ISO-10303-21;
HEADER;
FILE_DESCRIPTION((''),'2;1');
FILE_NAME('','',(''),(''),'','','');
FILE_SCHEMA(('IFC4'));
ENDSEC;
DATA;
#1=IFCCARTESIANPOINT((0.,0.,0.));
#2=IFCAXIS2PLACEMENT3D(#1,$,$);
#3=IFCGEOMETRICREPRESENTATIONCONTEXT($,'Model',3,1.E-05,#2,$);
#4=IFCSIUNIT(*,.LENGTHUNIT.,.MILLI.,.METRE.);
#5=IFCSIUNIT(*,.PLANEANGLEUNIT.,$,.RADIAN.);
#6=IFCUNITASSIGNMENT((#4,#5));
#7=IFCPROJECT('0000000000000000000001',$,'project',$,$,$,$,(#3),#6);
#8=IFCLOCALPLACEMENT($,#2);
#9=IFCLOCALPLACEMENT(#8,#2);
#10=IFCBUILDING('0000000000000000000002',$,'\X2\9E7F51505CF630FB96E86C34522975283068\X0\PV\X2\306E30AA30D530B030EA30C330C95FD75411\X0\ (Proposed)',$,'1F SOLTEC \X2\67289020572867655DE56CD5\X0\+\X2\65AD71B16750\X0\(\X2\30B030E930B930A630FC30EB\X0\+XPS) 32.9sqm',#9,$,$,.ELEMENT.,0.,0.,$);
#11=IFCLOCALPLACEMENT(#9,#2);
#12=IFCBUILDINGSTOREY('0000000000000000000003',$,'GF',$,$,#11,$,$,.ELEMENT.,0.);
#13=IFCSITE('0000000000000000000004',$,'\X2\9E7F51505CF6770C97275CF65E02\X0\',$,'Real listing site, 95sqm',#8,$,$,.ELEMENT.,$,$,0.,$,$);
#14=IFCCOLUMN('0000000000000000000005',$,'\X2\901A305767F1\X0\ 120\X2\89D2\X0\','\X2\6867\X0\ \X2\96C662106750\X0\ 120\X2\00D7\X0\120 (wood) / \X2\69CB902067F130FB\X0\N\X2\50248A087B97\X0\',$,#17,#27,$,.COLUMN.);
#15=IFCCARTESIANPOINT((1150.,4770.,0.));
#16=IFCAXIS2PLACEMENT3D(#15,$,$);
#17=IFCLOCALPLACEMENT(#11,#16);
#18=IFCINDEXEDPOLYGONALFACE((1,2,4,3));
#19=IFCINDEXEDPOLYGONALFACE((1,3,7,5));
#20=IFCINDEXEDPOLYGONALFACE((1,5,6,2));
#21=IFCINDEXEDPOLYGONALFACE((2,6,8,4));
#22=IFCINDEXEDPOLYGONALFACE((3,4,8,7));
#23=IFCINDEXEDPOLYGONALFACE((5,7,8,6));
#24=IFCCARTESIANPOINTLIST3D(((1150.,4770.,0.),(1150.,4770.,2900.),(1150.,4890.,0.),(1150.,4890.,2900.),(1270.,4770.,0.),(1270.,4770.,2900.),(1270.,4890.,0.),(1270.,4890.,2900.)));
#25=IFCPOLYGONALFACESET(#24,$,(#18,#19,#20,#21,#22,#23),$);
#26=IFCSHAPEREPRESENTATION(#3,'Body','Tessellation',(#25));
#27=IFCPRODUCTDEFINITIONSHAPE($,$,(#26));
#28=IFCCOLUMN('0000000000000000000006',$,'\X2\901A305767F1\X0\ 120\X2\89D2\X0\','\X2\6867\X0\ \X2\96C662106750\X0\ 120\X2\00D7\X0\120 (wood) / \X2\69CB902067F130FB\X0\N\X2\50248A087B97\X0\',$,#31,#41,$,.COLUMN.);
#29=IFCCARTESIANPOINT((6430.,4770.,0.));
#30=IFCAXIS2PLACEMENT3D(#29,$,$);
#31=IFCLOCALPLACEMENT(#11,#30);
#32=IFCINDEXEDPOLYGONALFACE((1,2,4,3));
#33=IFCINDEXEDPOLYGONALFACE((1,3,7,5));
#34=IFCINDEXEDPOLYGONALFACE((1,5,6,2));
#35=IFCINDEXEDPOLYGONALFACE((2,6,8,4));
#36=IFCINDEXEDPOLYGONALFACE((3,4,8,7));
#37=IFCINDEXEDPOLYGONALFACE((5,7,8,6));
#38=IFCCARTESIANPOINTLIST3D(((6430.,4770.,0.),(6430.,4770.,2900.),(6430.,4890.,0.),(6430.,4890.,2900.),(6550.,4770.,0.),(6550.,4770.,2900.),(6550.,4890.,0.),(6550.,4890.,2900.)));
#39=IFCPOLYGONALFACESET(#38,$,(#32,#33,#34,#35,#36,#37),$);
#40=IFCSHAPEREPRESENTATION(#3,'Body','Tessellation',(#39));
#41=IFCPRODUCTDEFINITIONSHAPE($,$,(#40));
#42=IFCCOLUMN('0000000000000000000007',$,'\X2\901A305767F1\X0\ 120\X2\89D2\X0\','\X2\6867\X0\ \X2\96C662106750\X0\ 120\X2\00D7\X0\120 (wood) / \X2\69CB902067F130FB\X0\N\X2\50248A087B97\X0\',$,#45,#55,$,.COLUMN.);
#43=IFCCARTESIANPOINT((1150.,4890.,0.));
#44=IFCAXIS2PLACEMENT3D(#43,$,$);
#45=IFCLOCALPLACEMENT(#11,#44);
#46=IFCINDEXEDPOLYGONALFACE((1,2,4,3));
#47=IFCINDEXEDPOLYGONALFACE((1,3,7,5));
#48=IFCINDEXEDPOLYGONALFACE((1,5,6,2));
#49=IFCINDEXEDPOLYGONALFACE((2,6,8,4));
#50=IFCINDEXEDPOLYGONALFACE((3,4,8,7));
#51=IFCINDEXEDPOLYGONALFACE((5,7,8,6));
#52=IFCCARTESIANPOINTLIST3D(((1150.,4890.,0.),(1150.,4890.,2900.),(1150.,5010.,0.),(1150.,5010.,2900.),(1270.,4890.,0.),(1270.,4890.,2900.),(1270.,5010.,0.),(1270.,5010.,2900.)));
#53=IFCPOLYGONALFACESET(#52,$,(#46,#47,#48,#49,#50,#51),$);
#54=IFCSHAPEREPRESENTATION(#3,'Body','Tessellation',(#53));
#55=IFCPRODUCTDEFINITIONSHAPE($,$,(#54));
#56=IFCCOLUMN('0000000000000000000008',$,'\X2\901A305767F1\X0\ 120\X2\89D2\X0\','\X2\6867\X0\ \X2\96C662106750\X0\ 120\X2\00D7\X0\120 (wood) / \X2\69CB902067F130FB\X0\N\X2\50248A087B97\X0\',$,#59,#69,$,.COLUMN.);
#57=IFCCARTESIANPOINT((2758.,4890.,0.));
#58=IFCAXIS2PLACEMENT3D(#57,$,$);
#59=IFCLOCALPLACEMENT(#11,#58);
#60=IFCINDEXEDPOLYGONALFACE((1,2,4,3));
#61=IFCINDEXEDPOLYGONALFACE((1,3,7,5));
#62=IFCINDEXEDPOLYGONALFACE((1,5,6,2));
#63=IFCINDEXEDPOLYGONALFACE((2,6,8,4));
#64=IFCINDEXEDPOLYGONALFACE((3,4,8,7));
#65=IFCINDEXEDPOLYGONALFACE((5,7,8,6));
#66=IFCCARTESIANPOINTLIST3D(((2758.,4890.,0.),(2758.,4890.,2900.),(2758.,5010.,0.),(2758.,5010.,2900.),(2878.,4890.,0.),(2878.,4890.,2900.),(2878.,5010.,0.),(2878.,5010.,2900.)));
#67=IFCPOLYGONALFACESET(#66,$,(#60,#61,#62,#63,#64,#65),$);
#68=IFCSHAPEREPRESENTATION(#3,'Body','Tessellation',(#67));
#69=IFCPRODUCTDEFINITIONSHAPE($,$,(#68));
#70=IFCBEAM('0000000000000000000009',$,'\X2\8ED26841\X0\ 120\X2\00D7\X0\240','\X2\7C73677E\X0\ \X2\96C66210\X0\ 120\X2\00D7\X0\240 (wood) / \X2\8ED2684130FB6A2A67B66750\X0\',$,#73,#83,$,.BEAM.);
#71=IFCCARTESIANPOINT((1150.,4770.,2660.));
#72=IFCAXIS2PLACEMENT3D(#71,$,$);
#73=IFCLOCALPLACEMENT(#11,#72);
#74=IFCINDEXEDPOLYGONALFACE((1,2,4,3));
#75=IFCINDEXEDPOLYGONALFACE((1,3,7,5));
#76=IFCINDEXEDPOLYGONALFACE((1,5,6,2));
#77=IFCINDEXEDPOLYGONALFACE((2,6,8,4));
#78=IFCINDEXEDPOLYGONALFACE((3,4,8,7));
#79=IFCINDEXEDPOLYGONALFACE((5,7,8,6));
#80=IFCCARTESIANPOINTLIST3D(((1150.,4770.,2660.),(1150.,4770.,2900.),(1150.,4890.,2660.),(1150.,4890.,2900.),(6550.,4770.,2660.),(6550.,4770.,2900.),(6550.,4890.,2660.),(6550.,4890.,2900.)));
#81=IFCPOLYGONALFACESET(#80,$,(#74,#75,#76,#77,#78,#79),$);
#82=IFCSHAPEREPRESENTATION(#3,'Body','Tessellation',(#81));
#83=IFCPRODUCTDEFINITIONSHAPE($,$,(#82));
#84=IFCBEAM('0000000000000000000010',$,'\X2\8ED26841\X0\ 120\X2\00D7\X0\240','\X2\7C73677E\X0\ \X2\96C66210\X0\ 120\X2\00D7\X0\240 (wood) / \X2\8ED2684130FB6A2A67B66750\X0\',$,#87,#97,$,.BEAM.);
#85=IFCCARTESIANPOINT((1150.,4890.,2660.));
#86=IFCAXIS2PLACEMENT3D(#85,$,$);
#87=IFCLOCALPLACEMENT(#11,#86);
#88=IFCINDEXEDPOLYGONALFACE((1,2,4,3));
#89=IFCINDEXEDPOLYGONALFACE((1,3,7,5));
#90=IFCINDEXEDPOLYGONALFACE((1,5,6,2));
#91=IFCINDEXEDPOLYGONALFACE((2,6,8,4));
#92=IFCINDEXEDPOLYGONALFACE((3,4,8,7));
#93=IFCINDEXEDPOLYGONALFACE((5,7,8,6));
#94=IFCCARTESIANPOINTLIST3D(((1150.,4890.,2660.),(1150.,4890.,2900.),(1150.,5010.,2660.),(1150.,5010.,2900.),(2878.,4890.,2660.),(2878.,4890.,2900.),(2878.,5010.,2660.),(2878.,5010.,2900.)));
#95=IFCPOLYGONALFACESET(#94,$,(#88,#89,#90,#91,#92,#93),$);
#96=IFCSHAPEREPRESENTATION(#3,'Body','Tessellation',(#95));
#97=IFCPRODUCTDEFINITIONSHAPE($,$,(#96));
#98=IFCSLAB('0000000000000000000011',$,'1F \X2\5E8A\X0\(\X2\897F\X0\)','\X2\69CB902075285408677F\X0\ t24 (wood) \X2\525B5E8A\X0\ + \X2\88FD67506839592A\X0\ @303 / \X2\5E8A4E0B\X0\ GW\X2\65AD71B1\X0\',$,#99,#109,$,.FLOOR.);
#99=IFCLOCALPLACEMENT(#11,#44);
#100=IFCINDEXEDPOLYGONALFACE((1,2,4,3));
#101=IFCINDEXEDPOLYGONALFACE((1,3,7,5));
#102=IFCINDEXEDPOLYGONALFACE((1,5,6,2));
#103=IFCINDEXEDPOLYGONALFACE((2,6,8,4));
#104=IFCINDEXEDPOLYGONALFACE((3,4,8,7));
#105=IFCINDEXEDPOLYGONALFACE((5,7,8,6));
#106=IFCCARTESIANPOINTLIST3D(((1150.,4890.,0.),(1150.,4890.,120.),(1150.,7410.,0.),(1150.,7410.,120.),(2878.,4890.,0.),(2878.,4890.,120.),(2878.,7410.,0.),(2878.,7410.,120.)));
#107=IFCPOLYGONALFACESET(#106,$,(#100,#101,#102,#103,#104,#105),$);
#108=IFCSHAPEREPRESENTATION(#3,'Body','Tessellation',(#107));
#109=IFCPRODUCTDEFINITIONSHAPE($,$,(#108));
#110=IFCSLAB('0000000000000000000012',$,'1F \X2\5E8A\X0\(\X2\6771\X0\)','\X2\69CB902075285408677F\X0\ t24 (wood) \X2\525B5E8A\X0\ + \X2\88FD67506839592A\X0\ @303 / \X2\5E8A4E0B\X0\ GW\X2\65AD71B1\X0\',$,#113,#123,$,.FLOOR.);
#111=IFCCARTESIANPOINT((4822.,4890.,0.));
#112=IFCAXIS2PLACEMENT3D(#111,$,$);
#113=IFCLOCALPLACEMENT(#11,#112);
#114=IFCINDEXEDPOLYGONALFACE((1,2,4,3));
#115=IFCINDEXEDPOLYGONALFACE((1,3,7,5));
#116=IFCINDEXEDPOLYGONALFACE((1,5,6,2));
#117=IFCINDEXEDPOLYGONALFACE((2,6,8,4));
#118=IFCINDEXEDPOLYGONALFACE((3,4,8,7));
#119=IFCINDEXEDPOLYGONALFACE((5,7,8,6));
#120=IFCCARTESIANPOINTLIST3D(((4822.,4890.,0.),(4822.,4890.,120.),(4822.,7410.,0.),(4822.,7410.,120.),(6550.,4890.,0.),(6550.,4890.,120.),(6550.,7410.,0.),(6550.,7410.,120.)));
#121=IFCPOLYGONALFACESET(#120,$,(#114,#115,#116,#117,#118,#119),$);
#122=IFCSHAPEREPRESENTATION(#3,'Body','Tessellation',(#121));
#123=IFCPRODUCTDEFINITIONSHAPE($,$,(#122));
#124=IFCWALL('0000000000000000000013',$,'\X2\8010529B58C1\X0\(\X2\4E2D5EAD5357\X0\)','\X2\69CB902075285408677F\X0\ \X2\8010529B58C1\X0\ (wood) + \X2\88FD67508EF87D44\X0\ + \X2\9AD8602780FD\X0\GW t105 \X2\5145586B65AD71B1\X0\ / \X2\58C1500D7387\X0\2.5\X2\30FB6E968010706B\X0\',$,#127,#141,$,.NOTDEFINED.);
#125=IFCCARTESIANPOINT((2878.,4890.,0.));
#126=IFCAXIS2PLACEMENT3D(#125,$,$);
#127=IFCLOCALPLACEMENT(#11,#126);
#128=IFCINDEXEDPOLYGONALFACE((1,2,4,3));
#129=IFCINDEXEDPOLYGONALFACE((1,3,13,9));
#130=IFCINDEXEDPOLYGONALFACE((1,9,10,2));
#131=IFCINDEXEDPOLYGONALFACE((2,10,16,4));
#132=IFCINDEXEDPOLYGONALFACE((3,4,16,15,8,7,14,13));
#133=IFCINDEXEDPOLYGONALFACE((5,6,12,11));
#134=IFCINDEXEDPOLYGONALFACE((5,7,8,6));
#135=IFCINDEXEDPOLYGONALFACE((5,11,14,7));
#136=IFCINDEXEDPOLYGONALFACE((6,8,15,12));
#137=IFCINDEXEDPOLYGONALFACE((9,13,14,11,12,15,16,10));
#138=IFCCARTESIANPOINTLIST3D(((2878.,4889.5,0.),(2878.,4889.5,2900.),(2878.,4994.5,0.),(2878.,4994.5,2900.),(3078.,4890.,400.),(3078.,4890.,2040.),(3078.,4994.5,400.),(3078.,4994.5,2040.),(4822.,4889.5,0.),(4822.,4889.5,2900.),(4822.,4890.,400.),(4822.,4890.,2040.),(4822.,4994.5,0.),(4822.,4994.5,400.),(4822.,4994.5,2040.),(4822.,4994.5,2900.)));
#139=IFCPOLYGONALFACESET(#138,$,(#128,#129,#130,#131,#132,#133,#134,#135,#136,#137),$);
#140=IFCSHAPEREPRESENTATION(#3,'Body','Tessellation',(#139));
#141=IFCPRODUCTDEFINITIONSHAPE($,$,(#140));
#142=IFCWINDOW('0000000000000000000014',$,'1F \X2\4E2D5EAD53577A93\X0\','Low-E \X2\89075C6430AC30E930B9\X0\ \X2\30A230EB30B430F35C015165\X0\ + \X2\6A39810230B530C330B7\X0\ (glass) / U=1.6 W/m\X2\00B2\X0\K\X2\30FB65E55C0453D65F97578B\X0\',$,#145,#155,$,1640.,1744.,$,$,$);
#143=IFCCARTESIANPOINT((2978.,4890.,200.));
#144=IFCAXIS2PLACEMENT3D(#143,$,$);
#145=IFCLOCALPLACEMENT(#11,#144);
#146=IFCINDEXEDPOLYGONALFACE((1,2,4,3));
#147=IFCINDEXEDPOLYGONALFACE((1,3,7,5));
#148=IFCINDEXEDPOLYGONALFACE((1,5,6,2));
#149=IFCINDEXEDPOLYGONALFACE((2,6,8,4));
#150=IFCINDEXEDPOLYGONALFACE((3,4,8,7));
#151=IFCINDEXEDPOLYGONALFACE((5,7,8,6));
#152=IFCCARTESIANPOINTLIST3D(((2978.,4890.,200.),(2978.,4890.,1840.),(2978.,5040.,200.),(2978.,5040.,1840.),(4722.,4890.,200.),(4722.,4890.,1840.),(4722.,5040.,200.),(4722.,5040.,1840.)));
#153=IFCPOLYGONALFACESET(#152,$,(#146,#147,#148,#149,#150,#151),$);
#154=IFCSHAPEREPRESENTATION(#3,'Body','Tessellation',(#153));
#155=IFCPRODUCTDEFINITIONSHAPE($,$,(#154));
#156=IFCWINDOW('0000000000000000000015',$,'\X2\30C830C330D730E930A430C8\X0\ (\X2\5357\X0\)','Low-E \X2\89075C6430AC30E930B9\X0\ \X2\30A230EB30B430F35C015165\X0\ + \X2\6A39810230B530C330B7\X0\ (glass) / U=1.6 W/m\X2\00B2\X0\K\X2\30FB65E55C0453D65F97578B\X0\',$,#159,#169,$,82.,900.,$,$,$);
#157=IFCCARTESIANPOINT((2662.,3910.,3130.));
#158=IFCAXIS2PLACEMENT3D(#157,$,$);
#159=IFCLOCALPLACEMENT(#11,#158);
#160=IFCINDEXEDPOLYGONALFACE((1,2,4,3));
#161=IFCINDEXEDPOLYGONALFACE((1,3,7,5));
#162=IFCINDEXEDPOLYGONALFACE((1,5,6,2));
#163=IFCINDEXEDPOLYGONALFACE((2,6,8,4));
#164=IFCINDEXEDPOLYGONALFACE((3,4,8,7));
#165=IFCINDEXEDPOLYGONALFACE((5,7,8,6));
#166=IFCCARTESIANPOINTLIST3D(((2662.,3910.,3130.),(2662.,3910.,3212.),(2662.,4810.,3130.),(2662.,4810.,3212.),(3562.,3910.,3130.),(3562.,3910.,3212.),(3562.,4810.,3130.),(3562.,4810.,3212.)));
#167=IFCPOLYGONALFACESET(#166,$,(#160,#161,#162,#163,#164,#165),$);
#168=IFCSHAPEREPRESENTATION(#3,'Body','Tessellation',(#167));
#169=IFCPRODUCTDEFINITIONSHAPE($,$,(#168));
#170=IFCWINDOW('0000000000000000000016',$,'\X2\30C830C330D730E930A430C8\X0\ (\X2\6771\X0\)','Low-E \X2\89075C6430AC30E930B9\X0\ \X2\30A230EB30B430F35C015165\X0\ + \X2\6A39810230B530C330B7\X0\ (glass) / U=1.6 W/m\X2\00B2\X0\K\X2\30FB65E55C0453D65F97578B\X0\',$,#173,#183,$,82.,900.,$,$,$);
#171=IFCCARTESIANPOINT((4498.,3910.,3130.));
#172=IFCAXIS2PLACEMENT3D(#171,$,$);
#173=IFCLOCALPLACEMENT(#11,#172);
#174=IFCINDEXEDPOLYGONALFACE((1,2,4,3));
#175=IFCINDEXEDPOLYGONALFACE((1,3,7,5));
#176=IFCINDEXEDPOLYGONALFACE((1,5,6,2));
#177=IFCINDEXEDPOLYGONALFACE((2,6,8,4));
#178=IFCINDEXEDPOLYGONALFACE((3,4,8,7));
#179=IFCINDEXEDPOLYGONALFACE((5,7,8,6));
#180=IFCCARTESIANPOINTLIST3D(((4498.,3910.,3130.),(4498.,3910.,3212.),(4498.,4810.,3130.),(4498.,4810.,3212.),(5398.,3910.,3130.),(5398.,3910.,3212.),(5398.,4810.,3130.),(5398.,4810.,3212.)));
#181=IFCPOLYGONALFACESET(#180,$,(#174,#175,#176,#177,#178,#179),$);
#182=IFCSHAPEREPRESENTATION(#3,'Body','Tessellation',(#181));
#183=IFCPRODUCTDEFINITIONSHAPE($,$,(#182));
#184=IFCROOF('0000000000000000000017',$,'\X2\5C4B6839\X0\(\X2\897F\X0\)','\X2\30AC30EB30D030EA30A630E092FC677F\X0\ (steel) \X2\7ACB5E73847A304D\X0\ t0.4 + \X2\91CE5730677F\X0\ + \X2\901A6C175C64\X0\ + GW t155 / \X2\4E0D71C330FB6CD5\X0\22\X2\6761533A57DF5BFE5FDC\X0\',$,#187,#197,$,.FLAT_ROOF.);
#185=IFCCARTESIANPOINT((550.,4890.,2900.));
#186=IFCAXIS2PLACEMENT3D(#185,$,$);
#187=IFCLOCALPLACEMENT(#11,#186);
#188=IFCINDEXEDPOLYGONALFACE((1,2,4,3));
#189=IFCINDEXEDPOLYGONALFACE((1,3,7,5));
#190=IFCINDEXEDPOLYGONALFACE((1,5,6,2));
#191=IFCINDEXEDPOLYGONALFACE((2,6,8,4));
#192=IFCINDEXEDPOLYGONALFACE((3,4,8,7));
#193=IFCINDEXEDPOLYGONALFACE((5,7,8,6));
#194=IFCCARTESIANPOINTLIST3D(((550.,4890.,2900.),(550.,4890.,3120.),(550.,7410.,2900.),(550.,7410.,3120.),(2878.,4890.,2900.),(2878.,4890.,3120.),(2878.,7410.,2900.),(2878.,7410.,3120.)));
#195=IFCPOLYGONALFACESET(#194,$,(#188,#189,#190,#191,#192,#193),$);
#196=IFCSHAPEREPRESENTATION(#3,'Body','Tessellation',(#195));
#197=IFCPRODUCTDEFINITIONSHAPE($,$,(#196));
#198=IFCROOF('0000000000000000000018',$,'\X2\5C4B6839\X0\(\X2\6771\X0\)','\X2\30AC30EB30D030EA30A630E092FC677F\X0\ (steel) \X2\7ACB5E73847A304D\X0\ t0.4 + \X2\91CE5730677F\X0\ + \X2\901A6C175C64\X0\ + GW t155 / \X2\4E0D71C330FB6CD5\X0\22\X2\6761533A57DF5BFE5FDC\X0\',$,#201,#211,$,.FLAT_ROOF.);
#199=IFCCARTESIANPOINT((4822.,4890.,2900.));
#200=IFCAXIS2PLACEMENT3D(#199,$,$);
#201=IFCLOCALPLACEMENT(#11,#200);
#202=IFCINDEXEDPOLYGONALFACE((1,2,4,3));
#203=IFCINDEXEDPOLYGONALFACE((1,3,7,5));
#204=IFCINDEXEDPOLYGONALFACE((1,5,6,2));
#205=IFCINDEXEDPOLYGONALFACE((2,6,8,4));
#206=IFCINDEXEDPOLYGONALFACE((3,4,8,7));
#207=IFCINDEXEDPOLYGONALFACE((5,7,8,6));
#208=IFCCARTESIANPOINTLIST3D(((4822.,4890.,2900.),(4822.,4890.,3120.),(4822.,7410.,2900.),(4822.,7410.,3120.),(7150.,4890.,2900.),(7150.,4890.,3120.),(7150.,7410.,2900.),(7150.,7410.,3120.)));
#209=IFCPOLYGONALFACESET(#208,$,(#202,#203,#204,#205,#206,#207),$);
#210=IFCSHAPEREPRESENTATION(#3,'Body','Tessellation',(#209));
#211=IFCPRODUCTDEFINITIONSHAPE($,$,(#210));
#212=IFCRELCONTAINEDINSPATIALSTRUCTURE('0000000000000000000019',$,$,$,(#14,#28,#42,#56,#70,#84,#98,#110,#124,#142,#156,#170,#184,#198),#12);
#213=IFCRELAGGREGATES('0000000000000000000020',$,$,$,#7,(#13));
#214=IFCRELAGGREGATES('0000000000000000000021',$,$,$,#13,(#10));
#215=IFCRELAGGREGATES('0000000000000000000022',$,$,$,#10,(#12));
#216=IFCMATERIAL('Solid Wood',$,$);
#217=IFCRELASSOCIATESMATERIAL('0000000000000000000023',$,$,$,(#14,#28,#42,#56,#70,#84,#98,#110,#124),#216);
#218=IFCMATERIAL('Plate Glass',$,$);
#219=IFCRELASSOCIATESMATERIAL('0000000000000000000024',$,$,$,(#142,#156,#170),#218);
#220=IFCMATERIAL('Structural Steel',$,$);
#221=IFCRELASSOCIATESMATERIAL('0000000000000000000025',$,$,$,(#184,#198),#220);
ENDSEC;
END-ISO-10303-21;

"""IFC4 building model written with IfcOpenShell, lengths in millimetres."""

from ifc_helpers import new_model, si_unit, frame, frame_2d, origin, place, context, project, spatial, rectangle, extrude, material, element, fill, save


model = new_model("IFC4")

# Units and contexts
model_context = context("Model", 3, precision=1e-05, world=origin())
ifc_project = project(units=[si_unit("LENGTHUNIT", "METRE", prefix="MILLI"), si_unit("PLANEANGLEUNIT", "RADIAN")], contexts=[model_context])

# Site, building, storey
site_placement = place(None, origin())
site = spatial("IfcSite", under=ifc_project, at=site_placement, Name="鹿児島県霧島市", ObjectType="Real listing site, 95sqm", CompositionType="ELEMENT", RefElevation=0.0)
building_placement = place(site_placement, origin())
building = spatial("IfcBuilding", under=site, at=building_placement, Name="鹿児島・雨水利用とPVのオフグリッド志向 (Proposed)", ObjectType="1F SOLTEC 木造在来工法+断熱材(グラスウール+XPS) 32.9sqm", CompositionType="ELEMENT", ElevationOfRefHeight=0.0, ElevationOfTerrain=0.0)
storey_placement = place(building_placement, origin())
storey = spatial("IfcBuildingStorey", under=building, at=storey_placement, Name="GF", CompositionType="ELEMENT", Elevation=0.0)

# Columns
ifc_material_1 = material(Name="Solid Wood")
column_1_placement = place(storey_placement, frame((1150.0, 4770.0, 0.0)))
element("IfcColumn", 1, at=column_1_placement, inside=storey, material=ifc_material_1, Name="通し柱 120角", Description="桧 集成材 120×120 (wood) / 構造柱・N値計算", PredefinedType="COLUMN", context=model_context, shape_type="SweptSolid", body=[
    extrude(rectangle(XDim=120.0, YDim=120.0, at=frame_2d((60.0, 60.0))), frame((1150.0, 4770.0, 0.0)), (0.0, 0.0, 1.0), 2900.0),
])
column_2_placement = place(storey_placement, frame((6430.0, 4770.0, 0.0)))
element("IfcColumn", 2, at=column_2_placement, inside=storey, material=ifc_material_1, Name="通し柱 120角", Description="桧 集成材 120×120 (wood) / 構造柱・N値計算", PredefinedType="COLUMN", context=model_context, shape_type="SweptSolid", body=[
    extrude(rectangle(XDim=120.0, YDim=120.0, at=frame_2d((60.0, 60.0))), frame((6430.0, 4770.0, 0.0)), (0.0, 0.0, 1.0), 2900.0),
])
column_3_placement = place(storey_placement, frame((1150.0, 4890.0, 0.0)))
element("IfcColumn", 3, at=column_3_placement, inside=storey, material=ifc_material_1, Name="通し柱 120角", Description="桧 集成材 120×120 (wood) / 構造柱・N値計算", PredefinedType="COLUMN", context=model_context, shape_type="SweptSolid", body=[
    extrude(rectangle(XDim=120.0, YDim=120.0, at=frame_2d((60.0, 60.0))), frame((1150.0, 4890.0, 0.0)), (0.0, 0.0, 1.0), 2900.0),
])
column_4_placement = place(storey_placement, frame((2758.0, 4890.0, 0.0)))
element("IfcColumn", 4, at=column_4_placement, inside=storey, material=ifc_material_1, Name="通し柱 120角", Description="桧 集成材 120×120 (wood) / 構造柱・N値計算", PredefinedType="COLUMN", context=model_context, shape_type="SweptSolid", body=[
    extrude(rectangle(XDim=120.0, YDim=120.0, at=frame_2d((60.0, 60.0))), frame((2758.0, 4890.0, 0.0)), (0.0, 0.0, 1.0), 2900.0),
])

# Beams
beam_1_placement = place(storey_placement, frame((1150.0, 4770.0, 2660.0)))
element("IfcBeam", 5, at=beam_1_placement, inside=storey, material=ifc_material_1, Name="軒桁 120×240", Description="米松 集成 120×240 (wood) / 軒桁・横架材", PredefinedType="BEAM", context=model_context, shape_type="SweptSolid", body=[
    extrude(rectangle(XDim=5400.0, YDim=120.0, at=frame_2d((2700.0, 60.0))), frame((1150.0, 4770.0, 2660.0)), (0.0, 0.0, 1.0), 240.0),
])
beam_2_placement = place(storey_placement, frame((1150.0, 4890.0, 2660.0)))
element("IfcBeam", 6, at=beam_2_placement, inside=storey, material=ifc_material_1, Name="軒桁 120×240", Description="米松 集成 120×240 (wood) / 軒桁・横架材", PredefinedType="BEAM", context=model_context, shape_type="SweptSolid", body=[
    extrude(rectangle(XDim=1728.0, YDim=120.0, at=frame_2d((864.0, 60.0))), frame((1150.0, 4890.0, 2660.0)), (0.0, 0.0, 1.0), 240.0),
])

# Slabs
slab_1_placement = place(storey_placement, frame((1150.0, 4890.0, 0.0)))
element("IfcSlab", 7, at=slab_1_placement, inside=storey, material=ifc_material_1, Name="1F 床(西)", Description="構造用合板 t24 (wood) 剛床 + 製材根太 @303 / 床下 GW断熱", PredefinedType="FLOOR", context=model_context, shape_type="SweptSolid", body=[
    extrude(rectangle(XDim=1728.0, YDim=2520.0, at=frame_2d((864.0, 1260.0))), frame((1150.0, 4890.0, 0.0)), (0.0, 0.0, 1.0), 120.0),
])
slab_2_placement = place(storey_placement, frame((4822.0, 4890.0, 0.0)))
element("IfcSlab", 8, at=slab_2_placement, inside=storey, material=ifc_material_1, Name="1F 床(東)", Description="構造用合板 t24 (wood) 剛床 + 製材根太 @303 / 床下 GW断熱", PredefinedType="FLOOR", context=model_context, shape_type="SweptSolid", body=[
    extrude(rectangle(XDim=1728.0, YDim=2520.0, at=frame_2d((864.0, 1260.0))), frame((4822.0, 4890.0, 0.0)), (0.0, 0.0, 1.0), 120.0),
])

# Wall, opening, window
wall_1_placement = place(storey_placement, frame((2878.0, 4890.0, 0.0)))
wall_1 = element("IfcWall", 9, at=wall_1_placement, inside=storey, material=ifc_material_1, Name="耐力壁(中庭南)", Description="構造用合板 耐力壁 (wood) + 製材軸組 + 高性能GW t105 充填断熱 / 壁倍率2.5・準耐火", PredefinedType="NOTDEFINED", context=model_context, shape_type="SweptSolid", body=[
    extrude(rectangle(XDim=1944.0, YDim=105.0, at=frame_2d((972.0, 52.0))), frame((2878.0, 4890.0, 0.0)), (0.0, 0.0, 1.0), 2900.0),
])
opening_placement = place(storey_placement, frame((2978.0, 4890.0, 200.0)))
opening = element("IfcOpeningElement", 10, at=opening_placement, cuts=wall_1, PredefinedType="NOTDEFINED", context=model_context, shape_type="SweptSolid", body=[
    extrude(rectangle(XDim=1744.0, YDim=150.0, at=frame_2d((872.0, 75.0))), frame((2978.0, 4890.0, 200.0)), (0.0, 0.0, 1.0), 1640.0),
])
ifc_material_2 = material(Name="Plate Glass")
window_1_placement = place(storey_placement, frame((2978.0, 4890.0, 200.0)))
window_1 = element("IfcWindow", 11, at=window_1_placement, inside=storey, material=ifc_material_2, Name="1F 中庭南窓", Description="Low-E 複層ガラス アルゴン封入 + 樹脂サッシ (glass) / U=1.6 W/m²K・日射取得型", OverallHeight=1640.0, OverallWidth=1744.0, context=model_context, shape_type="SweptSolid", body=[
    extrude(rectangle(XDim=1744.0, YDim=150.0, at=frame_2d((872.0, 75.0))), frame((2978.0, 4890.0, 200.0)), (0.0, 0.0, 1.0), 1640.0),
])
fill(opening, window_1)

# Windows
window_2_placement = place(storey_placement, frame((2662.0, 3910.0, 3130.0)))
element("IfcWindow", 12, at=window_2_placement, inside=storey, material=ifc_material_2, Name="トップライト (南)", Description="Low-E 複層ガラス アルゴン封入 + 樹脂サッシ (glass) / U=1.6 W/m²K・日射取得型", OverallHeight=82.0, OverallWidth=900.0, context=model_context, shape_type="SweptSolid", body=[
    extrude(rectangle(XDim=900.0, YDim=900.0, at=frame_2d((450.0, 450.0))), frame((2662.0, 3910.0, 3130.0)), (0.0, 0.0, 1.0), 82.0),
])
window_3_placement = place(storey_placement, frame((4498.0, 3910.0, 3130.0)))
element("IfcWindow", 13, at=window_3_placement, inside=storey, material=ifc_material_2, Name="トップライト (東)", Description="Low-E 複層ガラス アルゴン封入 + 樹脂サッシ (glass) / U=1.6 W/m²K・日射取得型", OverallHeight=82.0, OverallWidth=900.0, context=model_context, shape_type="SweptSolid", body=[
    extrude(rectangle(XDim=900.0, YDim=900.0, at=frame_2d((450.0, 450.0))), frame((4498.0, 3910.0, 3130.0)), (0.0, 0.0, 1.0), 82.0),
])

# Roofs
ifc_material_3 = material(Name="Structural Steel")
roof_1_placement = place(storey_placement, frame((550.0, 4890.0, 2900.0)))
element("IfcRoof", 14, at=roof_1_placement, inside=storey, material=ifc_material_3, Name="屋根(西)", Description="ガルバリウム鋼板 (steel) 立平葺き t0.4 + 野地板 + 通気層 + GW t155 / 不燃・法22条区域対応", PredefinedType="FLAT_ROOF", context=model_context, shape_type="SweptSolid", body=[
    extrude(rectangle(XDim=2328.0, YDim=2520.0, at=frame_2d((1164.0, 1260.0))), frame((550.0, 4890.0, 2900.0)), (0.0, 0.0, 1.0), 220.0),
])
roof_2_placement = place(storey_placement, frame((4822.0, 4890.0, 2900.0)))
element("IfcRoof", 15, at=roof_2_placement, inside=storey, material=ifc_material_3, Name="屋根(東)", Description="ガルバリウム鋼板 (steel) 立平葺き t0.4 + 野地板 + 通気層 + GW t155 / 不燃・法22条区域対応", PredefinedType="FLAT_ROOF", context=model_context, shape_type="SweptSolid", body=[
    extrude(rectangle(XDim=2328.0, YDim=2520.0, at=frame_2d((1164.0, 1260.0))), frame((4822.0, 4890.0, 2900.0)), (0.0, 0.0, 1.0), 220.0),
])

save(model, "model.ifc")
